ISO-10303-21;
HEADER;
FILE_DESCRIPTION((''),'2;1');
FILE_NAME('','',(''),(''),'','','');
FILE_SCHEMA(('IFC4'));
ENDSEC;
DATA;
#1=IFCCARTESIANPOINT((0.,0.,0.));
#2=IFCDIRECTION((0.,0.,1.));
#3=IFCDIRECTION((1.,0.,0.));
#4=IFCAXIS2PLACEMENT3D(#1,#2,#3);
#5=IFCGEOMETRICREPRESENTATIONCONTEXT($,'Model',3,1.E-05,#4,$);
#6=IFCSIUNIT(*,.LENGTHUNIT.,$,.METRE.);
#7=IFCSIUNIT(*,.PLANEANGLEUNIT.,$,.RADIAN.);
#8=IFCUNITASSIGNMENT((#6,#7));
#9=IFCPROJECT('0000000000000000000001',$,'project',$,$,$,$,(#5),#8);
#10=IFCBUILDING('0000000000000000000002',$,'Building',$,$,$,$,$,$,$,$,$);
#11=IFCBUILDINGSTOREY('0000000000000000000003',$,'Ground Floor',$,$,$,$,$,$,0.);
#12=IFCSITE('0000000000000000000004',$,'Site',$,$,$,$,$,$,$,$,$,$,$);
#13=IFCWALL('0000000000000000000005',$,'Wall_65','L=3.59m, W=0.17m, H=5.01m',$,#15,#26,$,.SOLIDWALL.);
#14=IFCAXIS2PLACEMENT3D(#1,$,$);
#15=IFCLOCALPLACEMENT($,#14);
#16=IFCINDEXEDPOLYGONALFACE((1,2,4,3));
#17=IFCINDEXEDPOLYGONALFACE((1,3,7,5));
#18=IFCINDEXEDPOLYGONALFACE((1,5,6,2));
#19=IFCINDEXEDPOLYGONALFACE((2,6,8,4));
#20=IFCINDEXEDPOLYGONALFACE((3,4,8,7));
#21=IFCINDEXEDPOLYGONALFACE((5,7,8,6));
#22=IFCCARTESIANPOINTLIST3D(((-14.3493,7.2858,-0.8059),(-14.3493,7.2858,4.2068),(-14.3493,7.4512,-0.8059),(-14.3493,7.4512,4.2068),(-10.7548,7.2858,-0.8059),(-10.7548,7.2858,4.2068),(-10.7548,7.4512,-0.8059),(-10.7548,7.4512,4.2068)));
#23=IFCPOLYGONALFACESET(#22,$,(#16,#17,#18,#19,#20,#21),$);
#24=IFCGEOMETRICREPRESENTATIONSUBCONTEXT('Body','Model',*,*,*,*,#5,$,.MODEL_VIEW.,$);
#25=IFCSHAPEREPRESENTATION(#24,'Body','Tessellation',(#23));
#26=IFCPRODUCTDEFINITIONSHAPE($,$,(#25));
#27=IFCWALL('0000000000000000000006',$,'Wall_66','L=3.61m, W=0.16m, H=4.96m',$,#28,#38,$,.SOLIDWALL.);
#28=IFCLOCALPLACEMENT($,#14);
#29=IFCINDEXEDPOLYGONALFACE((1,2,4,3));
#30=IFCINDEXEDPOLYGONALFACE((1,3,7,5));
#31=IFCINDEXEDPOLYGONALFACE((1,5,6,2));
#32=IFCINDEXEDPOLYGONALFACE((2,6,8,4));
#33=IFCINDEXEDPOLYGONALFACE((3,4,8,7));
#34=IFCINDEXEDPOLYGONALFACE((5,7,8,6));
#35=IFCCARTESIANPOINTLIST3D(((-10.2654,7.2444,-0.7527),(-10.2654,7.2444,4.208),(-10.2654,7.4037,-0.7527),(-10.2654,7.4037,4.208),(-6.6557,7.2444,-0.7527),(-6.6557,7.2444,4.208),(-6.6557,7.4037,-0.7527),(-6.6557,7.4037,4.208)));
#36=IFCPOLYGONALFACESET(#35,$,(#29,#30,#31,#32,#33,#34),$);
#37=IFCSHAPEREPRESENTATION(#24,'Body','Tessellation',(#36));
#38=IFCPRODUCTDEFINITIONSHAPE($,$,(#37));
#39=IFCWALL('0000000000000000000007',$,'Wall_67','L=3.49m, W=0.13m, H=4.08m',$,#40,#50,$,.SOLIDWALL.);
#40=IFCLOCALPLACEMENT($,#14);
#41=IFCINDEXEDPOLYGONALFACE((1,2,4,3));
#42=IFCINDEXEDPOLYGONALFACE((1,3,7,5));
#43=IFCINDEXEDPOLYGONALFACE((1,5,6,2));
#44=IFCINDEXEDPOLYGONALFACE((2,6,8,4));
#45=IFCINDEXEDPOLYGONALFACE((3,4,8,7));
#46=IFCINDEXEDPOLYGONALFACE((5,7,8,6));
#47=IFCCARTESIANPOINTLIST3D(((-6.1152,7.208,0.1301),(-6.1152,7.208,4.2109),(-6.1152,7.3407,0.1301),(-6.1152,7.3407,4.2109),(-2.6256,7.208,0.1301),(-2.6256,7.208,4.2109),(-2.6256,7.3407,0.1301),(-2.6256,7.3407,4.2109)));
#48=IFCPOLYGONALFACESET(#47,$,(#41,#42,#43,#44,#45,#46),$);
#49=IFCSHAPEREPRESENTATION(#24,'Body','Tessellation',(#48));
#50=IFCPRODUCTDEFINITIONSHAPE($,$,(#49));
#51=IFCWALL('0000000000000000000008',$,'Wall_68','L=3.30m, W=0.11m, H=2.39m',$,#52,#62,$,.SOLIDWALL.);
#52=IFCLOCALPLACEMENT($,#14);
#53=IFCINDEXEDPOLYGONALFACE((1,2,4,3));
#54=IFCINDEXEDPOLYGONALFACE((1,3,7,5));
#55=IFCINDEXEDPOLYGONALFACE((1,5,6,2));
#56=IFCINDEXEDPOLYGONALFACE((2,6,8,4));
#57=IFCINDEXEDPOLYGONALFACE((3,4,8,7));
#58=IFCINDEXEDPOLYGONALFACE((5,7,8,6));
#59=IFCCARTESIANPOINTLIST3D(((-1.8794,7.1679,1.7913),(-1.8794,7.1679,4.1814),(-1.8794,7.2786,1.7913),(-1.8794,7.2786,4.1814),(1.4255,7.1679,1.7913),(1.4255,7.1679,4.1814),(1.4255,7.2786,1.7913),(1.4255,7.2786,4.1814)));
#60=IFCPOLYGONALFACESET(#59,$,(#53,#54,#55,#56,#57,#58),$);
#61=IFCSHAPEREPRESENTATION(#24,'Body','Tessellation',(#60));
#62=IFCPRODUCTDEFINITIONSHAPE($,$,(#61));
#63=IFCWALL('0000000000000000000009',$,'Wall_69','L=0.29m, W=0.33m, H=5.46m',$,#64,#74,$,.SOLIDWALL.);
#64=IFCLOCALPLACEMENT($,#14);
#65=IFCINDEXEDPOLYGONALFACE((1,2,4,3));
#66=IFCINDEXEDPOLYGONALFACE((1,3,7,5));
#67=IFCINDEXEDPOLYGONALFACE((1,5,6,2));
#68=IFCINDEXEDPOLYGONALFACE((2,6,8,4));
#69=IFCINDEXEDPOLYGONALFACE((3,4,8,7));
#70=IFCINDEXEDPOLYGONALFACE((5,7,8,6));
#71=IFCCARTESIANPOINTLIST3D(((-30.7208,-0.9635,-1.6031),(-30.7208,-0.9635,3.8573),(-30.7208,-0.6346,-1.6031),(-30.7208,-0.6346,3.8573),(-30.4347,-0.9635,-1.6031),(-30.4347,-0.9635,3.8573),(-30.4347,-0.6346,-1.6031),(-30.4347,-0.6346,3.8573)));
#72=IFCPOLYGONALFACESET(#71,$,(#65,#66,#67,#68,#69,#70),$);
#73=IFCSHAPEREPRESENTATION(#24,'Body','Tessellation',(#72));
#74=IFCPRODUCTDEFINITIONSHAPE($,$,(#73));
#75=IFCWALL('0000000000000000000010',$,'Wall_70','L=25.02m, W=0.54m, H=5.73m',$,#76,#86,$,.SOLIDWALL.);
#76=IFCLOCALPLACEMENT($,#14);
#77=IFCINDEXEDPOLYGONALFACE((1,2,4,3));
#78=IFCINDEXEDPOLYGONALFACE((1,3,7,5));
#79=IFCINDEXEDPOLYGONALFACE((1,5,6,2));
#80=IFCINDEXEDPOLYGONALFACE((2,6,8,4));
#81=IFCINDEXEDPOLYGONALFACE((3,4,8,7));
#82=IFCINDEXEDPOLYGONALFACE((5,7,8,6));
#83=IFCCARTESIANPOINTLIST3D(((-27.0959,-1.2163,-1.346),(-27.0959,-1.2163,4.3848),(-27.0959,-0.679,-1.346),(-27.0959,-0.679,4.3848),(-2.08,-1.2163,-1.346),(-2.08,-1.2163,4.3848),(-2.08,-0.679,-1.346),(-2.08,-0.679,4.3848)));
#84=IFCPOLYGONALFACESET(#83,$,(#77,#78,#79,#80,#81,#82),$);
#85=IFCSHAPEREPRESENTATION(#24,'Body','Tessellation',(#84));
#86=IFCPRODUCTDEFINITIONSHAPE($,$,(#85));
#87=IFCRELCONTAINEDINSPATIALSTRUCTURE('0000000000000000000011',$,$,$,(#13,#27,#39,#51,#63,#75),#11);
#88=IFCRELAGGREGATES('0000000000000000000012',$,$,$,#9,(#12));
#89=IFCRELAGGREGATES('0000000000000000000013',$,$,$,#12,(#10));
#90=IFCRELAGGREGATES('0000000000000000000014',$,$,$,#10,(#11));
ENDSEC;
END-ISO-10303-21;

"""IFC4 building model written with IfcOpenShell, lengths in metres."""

from ifc_helpers import new_model, si_unit, frame, origin_with_axes, origin_2d, context, subcontext, project, spatial, rectangle, extrude, element, save


model = new_model("IFC4")

# Units and contexts
model_context = context("Model", 3, precision=1e-05, world=origin_with_axes())
body_context = subcontext(model_context, "Body", "Model", "MODEL_VIEW")
ifc_project = project(units=[si_unit("LENGTHUNIT", "METRE"), si_unit("PLANEANGLEUNIT", "RADIAN")], contexts=[model_context])

# Site, building, storey
site = spatial("IfcSite", under=ifc_project, Name="Site")
building = spatial("IfcBuilding", under=site, Name="Building")
storey = spatial("IfcBuildingStorey", under=building, Name="Ground Floor", Elevation=0.0)

# Walls
element("IfcWall", 1, inside=storey, Name="Wall_65", Description="L=3.59m, W=0.17m, H=5.01m", PredefinedType="SOLIDWALL", context=body_context, shape_type="SweptSolid", body=[
    extrude(rectangle(XDim=3.5945, YDim=0.1655, at=origin_2d()), frame((-12.552, 7.3685, -0.8059), z_axis=(0.0, 0.0, 1.0), x_axis=(1.0, 0.0, 0.0)), (0.0, 0.0, 1.0), 5.0127),
])
element("IfcWall", 2, inside=storey, Name="Wall_66", Description="L=3.61m, W=0.16m, H=4.96m", PredefinedType="SOLIDWALL", context=body_context, shape_type="SweptSolid", body=[
    extrude(rectangle(XDim=3.6097, YDim=0.1593, at=origin_2d()), frame((-8.4605, 7.324, -0.7527), z_axis=(0.0, 0.0, 1.0), x_axis=(1.0, 0.0, 0.0)), (0.0, 0.0, 1.0), 4.9606),
])
element("IfcWall", 3, inside=storey, Name="Wall_67", Description="L=3.49m, W=0.13m, H=4.08m", PredefinedType="SOLIDWALL", context=body_context, shape_type="SweptSolid", body=[
    extrude(rectangle(XDim=3.4897, YDim=0.1327, at=origin_2d()), frame((-4.3704, 7.2743, 0.1301), z_axis=(0.0, 0.0, 1.0), x_axis=(1.0, 0.0, 0.0)), (0.0, 0.0, 1.0), 4.0809),
])
element("IfcWall", 4, inside=storey, Name="Wall_68", Description="L=3.30m, W=0.11m, H=2.39m", PredefinedType="SOLIDWALL", context=body_context, shape_type="SweptSolid", body=[
    extrude(rectangle(XDim=3.305, YDim=0.1107, at=origin_2d()), frame((-0.227, 7.2232, 1.7913), z_axis=(0.0, 0.0, 1.0), x_axis=(1.0, 0.0, 0.0)), (0.0, 0.0, 1.0), 2.3901),
])
element("IfcWall", 5, inside=storey, Name="Wall_69", Description="L=0.29m, W=0.33m, H=5.46m", PredefinedType="SOLIDWALL", context=body_context, shape_type="SweptSolid", body=[
    extrude(rectangle(XDim=0.2861, YDim=0.3289, at=origin_2d()), frame((-30.5778, -0.799, -1.6031), z_axis=(0.0, 0.0, 1.0), x_axis=(1.0, 0.0, 0.0)), (0.0, 0.0, 1.0), 5.4605),
])
element("IfcWall", 6, inside=storey, Name="Wall_70", Description="L=25.02m, W=0.54m, H=5.73m", PredefinedType="SOLIDWALL", context=body_context, shape_type="SweptSolid", body=[
    extrude(rectangle(XDim=25.0159, YDim=0.5374, at=origin_2d()), frame((-14.5879, -0.9476, -1.346), z_axis=(0.0, 0.0, 1.0), x_axis=(1.0, 0.0, 0.0)), (0.0, 0.0, 1.0), 5.7308),
])

save(model, "model.ifc")
